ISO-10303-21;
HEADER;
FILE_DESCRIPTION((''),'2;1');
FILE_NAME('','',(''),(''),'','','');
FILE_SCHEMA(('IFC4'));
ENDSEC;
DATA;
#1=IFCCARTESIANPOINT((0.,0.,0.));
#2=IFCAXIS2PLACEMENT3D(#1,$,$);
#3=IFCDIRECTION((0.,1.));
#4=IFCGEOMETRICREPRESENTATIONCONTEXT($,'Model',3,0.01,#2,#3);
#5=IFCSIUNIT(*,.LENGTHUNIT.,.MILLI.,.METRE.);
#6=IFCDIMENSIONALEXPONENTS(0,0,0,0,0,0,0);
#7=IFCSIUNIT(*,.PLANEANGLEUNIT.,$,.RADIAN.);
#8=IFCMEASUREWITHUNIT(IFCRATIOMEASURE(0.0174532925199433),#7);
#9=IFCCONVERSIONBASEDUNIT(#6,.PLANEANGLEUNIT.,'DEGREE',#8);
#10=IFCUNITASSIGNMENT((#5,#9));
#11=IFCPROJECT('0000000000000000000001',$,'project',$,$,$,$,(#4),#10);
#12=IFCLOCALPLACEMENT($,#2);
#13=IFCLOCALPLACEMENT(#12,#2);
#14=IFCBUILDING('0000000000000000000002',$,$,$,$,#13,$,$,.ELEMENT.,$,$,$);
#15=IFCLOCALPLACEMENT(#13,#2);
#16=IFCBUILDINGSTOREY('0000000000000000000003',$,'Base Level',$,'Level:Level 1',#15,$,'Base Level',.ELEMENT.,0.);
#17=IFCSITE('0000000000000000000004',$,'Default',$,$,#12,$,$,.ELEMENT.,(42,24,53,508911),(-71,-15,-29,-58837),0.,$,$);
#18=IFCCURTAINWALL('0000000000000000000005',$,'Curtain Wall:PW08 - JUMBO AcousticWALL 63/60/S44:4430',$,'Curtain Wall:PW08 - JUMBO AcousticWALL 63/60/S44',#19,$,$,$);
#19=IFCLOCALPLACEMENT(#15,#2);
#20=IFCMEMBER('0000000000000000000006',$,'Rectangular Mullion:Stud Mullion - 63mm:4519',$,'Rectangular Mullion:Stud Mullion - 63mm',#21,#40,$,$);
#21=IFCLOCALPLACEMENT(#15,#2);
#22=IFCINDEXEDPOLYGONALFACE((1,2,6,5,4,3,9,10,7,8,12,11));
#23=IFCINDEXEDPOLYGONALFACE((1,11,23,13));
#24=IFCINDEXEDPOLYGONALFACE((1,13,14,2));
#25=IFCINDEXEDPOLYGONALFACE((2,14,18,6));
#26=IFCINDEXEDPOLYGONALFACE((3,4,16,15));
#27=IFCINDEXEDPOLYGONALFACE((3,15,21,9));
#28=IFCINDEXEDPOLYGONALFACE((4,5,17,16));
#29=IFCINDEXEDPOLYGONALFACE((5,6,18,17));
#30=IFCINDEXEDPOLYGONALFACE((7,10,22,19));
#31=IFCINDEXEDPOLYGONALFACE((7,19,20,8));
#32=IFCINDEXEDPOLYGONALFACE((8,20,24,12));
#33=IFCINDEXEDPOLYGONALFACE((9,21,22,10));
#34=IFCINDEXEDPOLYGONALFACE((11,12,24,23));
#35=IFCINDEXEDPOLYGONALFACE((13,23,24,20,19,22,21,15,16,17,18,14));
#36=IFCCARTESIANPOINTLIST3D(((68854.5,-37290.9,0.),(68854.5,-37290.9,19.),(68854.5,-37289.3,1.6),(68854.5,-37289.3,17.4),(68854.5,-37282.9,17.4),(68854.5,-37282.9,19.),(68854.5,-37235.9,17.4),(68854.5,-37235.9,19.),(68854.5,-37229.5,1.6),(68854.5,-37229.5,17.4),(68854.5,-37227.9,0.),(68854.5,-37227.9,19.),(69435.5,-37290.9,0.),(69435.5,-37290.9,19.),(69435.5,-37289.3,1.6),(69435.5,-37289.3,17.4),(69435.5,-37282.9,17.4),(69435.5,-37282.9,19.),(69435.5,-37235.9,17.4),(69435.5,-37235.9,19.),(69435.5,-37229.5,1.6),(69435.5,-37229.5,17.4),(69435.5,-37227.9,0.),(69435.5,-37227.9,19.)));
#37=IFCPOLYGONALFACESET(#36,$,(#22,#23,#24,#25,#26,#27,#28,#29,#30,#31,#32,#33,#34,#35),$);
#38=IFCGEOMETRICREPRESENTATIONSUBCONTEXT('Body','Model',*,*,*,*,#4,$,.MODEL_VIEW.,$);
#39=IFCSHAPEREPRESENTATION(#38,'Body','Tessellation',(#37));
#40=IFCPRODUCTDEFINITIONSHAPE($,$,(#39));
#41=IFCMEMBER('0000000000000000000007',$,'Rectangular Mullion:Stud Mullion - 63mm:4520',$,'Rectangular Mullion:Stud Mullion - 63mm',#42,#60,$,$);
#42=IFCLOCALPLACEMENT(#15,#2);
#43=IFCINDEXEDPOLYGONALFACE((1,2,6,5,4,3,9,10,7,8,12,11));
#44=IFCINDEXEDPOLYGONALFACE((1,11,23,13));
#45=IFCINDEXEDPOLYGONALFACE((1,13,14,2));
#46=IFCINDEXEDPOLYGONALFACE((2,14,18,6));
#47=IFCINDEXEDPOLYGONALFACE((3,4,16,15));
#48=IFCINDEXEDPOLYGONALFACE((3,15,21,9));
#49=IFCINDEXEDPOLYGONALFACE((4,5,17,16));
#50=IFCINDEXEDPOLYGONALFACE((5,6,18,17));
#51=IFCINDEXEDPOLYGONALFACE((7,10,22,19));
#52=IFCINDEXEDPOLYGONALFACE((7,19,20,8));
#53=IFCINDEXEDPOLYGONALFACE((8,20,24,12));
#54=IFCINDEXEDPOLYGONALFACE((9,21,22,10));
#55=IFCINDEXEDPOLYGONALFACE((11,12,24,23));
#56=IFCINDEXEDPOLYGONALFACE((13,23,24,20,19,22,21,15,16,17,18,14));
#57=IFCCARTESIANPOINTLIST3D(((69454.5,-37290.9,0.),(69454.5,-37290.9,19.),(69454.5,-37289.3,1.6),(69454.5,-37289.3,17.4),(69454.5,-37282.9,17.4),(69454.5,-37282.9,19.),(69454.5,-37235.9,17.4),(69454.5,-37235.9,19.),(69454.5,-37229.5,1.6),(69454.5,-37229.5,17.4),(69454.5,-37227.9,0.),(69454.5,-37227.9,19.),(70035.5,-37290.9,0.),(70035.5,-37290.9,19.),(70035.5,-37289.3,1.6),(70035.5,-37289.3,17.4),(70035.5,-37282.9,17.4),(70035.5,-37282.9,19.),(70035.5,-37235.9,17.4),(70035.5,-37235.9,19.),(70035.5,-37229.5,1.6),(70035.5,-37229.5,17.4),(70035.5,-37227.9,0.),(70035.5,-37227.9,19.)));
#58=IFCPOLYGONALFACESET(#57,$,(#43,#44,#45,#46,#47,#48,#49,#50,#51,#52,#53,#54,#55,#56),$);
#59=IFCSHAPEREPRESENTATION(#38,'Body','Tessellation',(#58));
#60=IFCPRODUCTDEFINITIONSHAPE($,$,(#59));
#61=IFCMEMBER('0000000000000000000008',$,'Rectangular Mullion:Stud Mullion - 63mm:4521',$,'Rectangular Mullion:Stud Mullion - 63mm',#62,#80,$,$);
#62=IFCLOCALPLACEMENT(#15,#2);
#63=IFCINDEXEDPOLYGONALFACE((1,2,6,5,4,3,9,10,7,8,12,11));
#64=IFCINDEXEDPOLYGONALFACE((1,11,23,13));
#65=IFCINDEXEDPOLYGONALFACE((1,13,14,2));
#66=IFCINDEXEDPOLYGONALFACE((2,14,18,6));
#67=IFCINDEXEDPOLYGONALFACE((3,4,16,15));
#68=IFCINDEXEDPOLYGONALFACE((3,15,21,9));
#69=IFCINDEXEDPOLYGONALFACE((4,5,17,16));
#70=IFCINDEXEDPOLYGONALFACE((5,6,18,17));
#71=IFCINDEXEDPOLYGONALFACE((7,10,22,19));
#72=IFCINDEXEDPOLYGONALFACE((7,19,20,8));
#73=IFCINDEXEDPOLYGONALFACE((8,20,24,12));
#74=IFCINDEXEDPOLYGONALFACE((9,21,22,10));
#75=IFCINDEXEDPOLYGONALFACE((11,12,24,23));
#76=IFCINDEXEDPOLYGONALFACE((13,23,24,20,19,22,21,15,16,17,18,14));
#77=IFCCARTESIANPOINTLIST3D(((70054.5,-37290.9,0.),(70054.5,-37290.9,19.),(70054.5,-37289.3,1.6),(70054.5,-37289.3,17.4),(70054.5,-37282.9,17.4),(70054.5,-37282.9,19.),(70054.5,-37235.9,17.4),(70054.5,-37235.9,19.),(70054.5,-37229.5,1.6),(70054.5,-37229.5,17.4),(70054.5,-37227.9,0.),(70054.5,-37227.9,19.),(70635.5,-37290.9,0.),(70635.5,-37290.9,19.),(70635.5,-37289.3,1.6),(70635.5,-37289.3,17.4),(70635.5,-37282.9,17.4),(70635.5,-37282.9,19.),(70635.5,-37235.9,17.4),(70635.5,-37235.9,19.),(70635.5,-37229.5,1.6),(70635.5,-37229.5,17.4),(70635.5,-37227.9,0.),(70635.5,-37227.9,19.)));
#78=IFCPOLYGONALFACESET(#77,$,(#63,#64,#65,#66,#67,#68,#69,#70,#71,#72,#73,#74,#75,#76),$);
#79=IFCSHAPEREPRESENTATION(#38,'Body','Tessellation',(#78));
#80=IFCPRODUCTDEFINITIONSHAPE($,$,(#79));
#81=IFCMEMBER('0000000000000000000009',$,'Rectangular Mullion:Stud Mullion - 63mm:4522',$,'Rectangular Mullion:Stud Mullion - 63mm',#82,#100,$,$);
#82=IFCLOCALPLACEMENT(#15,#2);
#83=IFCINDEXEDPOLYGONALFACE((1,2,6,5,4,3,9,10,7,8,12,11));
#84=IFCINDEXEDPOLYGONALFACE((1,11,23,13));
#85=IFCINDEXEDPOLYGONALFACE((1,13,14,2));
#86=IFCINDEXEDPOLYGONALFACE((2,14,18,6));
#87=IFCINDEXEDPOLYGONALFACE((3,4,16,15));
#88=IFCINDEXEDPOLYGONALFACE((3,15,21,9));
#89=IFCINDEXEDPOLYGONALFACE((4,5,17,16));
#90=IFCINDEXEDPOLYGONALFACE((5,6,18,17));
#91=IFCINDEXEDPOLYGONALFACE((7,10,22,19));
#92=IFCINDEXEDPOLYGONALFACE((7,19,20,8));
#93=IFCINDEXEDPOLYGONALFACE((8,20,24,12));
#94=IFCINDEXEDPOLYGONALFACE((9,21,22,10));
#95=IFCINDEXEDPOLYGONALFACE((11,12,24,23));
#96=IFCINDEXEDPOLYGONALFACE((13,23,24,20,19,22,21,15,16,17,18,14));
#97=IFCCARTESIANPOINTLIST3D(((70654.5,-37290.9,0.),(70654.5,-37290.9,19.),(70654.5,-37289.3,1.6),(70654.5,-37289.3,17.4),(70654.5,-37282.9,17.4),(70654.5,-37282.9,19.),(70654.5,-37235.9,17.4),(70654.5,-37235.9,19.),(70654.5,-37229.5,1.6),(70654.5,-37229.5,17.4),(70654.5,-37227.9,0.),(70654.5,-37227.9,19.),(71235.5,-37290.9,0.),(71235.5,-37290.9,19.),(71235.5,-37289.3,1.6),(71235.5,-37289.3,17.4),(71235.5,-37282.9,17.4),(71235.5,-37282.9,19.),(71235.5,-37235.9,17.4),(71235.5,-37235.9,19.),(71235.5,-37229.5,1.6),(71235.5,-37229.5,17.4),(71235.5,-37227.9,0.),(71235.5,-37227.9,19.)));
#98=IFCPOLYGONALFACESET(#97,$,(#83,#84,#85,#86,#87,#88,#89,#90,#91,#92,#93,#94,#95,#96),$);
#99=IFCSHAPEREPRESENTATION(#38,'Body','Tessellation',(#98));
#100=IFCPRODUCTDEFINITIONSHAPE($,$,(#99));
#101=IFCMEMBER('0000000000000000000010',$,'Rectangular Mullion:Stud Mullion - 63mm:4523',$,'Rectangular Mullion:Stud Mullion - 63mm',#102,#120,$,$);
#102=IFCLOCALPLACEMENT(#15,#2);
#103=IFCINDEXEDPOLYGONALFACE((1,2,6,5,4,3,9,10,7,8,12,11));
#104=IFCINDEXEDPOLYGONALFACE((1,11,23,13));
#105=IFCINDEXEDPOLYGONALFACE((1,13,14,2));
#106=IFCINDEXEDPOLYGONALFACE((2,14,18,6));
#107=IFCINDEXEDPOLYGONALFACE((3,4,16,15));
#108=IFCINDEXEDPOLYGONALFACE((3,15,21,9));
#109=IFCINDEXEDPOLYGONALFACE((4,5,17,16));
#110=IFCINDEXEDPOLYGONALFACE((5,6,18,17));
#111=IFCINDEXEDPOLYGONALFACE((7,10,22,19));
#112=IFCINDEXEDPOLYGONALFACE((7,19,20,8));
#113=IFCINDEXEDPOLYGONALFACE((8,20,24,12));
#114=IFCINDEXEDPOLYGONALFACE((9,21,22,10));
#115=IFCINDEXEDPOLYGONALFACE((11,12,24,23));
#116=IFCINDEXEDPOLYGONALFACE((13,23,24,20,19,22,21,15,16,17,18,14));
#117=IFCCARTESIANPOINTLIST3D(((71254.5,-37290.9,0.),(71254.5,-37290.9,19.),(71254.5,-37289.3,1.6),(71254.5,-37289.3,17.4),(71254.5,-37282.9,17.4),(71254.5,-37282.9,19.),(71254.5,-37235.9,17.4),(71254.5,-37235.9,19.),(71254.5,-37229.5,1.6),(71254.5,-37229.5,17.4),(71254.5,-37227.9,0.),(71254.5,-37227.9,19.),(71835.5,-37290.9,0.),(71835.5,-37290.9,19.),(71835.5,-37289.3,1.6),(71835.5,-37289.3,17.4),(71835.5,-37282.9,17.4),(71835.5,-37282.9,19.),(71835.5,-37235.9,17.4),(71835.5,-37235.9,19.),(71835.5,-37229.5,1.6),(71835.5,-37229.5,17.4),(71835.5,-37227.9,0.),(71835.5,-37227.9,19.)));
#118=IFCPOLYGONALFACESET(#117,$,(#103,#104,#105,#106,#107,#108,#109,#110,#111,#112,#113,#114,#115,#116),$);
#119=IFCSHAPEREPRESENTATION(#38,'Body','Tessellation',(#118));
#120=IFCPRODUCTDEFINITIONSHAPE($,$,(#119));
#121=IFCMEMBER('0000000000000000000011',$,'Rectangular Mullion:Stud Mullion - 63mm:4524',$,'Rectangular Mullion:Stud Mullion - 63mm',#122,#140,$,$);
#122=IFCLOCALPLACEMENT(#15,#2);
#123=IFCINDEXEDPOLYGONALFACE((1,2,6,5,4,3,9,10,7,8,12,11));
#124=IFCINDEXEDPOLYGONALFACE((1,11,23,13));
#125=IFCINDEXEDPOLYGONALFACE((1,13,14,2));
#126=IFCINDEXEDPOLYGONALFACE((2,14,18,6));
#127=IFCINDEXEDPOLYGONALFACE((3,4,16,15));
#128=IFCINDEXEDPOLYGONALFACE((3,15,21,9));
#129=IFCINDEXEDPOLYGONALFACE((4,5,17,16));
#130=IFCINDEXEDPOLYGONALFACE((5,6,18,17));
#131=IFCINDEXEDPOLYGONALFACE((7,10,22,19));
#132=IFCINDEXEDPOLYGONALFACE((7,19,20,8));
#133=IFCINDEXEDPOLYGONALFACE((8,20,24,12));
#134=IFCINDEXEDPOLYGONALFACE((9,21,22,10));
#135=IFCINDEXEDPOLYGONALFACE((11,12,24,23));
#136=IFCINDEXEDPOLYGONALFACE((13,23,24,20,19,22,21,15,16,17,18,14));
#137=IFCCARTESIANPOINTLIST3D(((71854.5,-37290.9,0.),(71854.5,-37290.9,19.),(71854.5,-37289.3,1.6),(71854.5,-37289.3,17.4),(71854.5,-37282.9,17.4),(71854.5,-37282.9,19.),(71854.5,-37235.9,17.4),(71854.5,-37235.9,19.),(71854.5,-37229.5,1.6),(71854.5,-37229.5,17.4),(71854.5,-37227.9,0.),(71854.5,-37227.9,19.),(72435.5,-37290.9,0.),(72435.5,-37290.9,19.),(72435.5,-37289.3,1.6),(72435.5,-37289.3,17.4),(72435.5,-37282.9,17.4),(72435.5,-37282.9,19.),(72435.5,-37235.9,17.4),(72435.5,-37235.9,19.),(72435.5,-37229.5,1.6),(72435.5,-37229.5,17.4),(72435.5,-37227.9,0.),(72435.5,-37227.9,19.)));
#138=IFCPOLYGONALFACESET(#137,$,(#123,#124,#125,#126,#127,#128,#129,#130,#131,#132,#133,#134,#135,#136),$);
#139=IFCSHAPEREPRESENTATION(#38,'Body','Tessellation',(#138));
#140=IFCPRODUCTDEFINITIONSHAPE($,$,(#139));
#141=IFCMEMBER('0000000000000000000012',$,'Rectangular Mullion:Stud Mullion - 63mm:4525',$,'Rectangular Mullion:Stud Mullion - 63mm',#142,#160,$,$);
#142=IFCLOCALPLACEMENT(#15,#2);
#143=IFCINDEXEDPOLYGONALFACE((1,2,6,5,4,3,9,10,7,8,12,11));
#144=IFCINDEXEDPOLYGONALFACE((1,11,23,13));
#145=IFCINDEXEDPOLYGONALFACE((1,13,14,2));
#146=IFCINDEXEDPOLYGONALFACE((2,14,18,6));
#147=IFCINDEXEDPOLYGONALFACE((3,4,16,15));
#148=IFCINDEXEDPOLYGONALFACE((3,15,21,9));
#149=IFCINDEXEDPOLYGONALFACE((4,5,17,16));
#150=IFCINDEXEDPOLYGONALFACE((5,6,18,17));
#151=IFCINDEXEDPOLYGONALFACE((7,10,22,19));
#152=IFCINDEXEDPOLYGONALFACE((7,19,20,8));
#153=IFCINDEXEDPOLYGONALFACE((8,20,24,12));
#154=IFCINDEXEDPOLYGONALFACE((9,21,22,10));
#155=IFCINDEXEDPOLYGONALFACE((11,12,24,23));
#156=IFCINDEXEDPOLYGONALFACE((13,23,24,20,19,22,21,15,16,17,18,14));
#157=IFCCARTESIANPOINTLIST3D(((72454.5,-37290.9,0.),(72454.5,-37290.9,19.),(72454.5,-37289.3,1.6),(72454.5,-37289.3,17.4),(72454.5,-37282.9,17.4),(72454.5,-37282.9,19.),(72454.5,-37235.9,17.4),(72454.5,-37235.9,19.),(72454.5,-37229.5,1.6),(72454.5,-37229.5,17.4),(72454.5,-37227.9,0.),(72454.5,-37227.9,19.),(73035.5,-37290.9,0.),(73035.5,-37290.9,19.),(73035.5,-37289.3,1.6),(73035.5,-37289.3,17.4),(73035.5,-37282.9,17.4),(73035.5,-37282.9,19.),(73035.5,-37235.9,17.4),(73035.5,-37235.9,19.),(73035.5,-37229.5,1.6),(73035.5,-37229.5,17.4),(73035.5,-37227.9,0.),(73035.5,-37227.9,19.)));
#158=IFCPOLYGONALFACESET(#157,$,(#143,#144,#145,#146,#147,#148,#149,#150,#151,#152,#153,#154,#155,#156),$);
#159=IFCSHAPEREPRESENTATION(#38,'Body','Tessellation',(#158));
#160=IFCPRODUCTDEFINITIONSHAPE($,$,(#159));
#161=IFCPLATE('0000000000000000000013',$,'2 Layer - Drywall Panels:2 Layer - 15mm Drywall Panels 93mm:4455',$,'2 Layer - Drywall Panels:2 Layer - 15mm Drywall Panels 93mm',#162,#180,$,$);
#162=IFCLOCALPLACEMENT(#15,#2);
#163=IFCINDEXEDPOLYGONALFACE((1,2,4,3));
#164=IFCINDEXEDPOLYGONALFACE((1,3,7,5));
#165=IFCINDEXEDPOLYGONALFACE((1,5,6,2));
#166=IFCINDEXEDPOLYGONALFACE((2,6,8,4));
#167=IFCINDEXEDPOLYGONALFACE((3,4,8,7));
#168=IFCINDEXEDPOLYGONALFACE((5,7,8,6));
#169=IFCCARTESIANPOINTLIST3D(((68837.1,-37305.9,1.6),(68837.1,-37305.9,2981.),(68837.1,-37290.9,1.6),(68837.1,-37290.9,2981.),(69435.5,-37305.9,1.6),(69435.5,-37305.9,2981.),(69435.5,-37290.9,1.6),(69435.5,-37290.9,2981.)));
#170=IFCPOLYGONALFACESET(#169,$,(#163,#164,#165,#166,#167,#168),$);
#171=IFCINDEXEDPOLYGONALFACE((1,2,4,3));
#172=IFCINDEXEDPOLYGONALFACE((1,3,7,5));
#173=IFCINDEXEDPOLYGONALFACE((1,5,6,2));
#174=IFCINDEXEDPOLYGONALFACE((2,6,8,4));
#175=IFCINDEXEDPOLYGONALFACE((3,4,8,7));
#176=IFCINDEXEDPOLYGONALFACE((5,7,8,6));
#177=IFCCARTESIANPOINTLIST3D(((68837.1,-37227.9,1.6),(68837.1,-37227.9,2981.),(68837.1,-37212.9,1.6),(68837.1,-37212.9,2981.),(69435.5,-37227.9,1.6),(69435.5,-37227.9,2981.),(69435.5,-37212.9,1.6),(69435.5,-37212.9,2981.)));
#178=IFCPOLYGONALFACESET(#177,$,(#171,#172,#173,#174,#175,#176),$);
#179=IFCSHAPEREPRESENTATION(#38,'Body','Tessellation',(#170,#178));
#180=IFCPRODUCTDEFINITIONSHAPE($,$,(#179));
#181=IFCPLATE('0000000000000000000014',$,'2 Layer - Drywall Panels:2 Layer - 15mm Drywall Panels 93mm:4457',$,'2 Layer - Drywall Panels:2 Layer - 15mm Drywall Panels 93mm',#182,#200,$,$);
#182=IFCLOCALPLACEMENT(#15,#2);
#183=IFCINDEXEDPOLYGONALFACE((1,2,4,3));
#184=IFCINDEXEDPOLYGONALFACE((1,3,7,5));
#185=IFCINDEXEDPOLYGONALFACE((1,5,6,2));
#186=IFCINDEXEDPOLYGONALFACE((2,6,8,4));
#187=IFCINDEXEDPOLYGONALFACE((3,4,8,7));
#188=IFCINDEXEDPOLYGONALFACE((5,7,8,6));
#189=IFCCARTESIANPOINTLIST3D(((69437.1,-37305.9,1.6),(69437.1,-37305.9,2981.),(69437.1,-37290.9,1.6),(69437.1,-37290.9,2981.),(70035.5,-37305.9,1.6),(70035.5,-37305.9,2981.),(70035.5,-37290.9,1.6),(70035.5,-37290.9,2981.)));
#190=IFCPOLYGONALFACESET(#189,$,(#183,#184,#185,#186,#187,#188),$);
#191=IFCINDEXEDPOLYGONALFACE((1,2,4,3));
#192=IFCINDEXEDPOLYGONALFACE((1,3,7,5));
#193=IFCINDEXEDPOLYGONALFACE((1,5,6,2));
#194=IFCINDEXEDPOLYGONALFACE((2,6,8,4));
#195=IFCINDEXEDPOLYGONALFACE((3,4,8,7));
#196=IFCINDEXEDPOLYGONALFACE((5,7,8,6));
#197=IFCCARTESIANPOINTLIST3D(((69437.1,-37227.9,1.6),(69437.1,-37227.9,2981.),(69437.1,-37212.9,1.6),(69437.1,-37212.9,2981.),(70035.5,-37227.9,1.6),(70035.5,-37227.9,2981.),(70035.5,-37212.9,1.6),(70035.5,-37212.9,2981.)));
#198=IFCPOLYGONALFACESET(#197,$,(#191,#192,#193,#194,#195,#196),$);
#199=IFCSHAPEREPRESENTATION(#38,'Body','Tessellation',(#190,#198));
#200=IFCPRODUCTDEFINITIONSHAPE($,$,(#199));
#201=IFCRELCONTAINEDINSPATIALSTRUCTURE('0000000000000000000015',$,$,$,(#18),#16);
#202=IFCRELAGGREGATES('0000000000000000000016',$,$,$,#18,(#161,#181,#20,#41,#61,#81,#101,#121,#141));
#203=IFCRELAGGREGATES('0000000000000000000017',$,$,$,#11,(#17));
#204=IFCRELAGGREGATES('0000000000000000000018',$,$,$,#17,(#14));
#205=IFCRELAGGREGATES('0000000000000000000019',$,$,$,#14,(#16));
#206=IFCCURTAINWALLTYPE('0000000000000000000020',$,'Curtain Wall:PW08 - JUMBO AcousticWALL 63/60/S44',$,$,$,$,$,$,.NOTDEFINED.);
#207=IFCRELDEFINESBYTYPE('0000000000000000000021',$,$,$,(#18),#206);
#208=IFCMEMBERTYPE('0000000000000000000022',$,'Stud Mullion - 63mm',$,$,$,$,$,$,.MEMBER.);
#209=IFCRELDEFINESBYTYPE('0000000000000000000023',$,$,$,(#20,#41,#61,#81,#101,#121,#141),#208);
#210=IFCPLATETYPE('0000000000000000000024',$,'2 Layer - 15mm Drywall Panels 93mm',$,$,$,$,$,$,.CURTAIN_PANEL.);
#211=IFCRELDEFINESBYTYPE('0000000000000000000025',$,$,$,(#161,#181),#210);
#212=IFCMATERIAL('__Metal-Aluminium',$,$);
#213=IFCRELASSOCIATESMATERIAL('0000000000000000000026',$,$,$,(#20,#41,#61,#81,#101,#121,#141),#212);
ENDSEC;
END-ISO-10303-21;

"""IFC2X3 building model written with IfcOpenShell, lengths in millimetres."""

from ifc_helpers import new_model, entity, si_unit, converted_unit, direction, frame, frame_2d, origin, place, context, subcontext, project, spatial, polyline, rectangle, outline, extrude, source, transform, mapped, material, type_object, type_shapes, element, aggregate, save


model = new_model("IFC2X3")

# Units and contexts
model_context = context("Model", 3, precision=0.01, world=origin(), true_north=direction((0.0, 1.0)))
body_context = subcontext(model_context, "Body", "Model", "MODEL_VIEW")
ifc_project = project(units=[si_unit("LENGTHUNIT", "METRE", prefix="MILLI"), converted_unit("PLANEANGLEUNIT", "DEGREE", entity("IfcRatioMeasure", 0.0174532925199433), si_unit("PLANEANGLEUNIT", "RADIAN"), dimensions=[0, 0, 0, 0, 0, 0, 0])], contexts=[model_context])

# Site, building, storey
site_placement = place(None, origin())
site = spatial("IfcSite", under=ifc_project, at=site_placement, Name="Default", CompositionType="ELEMENT", RefLatitude=(42, 24, 53, 508911), RefLongitude=(-71, -15, -29, -58837), RefElevation=0.0)
building_placement = place(site_placement, origin())
building = spatial("IfcBuilding", under=site, at=building_placement, CompositionType="ELEMENT")
storey_placement = place(building_placement, origin())
storey = spatial("IfcBuildingStorey", under=building, at=storey_placement, Name="Base Level", ObjectType="Level:Level 1", LongName="Base Level", CompositionType="ELEMENT", Elevation=0.0)

# Curtain wall, members, plates
curtain_wall_type = type_object("IfcCurtainWallType", Name="Curtain Wall:PW08 - JUMBO AcousticWALL 63/60/S44", PredefinedType="NOTDEFINED")
curtain_wall_placement = place(building_placement, origin())
curtain_wall = element("IfcCurtainWall", 1, at=curtain_wall_placement, inside=storey, type_object=curtain_wall_type, Name="Curtain Wall:PW08 - JUMBO AcousticWALL 63/60/S44:4430", ObjectType="Curtain Wall:PW08 - JUMBO AcousticWALL 63/60/S44")
ifc_material = material(Name="__Metal-Aluminium")
member_type_1 = type_object("IfcMemberType", Name="Stud Mullion - 63mm", PredefinedType="MEMBER")
shared_shape_1 = source(origin(), body_context, "Body", "SweptSolid", [
    extrude(outline(polyline([(23.5, -6.6), (31.5, -6.6), (31.5, 12.4), (-31.5, 12.4), (-31.5, -6.6), (-23.5, -6.6), (-23.5, -5.0), (-29.9, -5.0), (-29.9, 10.8), (29.9, 10.8), (29.9, -5.0), (23.5, -5.0), (23.5, -6.6)])), frame((-12.4, 0.0, -581.0), z_axis=(0.0, 0.0, 1.0), x_axis=(0.0, -1.0, 0.0)), (0.0, 0.0, 1.0), 581.0),
])
type_shapes(member_type_1, [shared_shape_1])
member_1_placement = place(building_placement, frame((68854.5, -37259.4, 0.0), z_axis=(-1.0, 0.0, 0.0), x_axis=(0.0, 0.0, -1.0)))
member_1 = element("IfcMember", 2, at=member_1_placement, type_object=member_type_1, material=ifc_material, Name="Rectangular Mullion:Stud Mullion - 63mm:4519", ObjectType="Rectangular Mullion:Stud Mullion - 63mm", context=body_context, shape_type="MappedRepresentation", body=[
    mapped(shared_shape_1, transform((0.0, 0.0, 0.0), scale=1.0)),
])
member_2_placement = place(building_placement, frame((69454.5, -37259.4, 0.0), z_axis=(-1.0, 0.0, 0.0), x_axis=(0.0, 0.0, -1.0)))
member_2 = element("IfcMember", 3, at=member_2_placement, type_object=member_type_1, material=ifc_material, Name="Rectangular Mullion:Stud Mullion - 63mm:4520", ObjectType="Rectangular Mullion:Stud Mullion - 63mm", context=body_context, shape_type="MappedRepresentation", body=[
    mapped(shared_shape_1, transform((0.0, 0.0, 0.0), scale=1.0)),
])
member_3_placement = place(building_placement, frame((70054.5, -37259.4, 0.0), z_axis=(-1.0, 0.0, 0.0), x_axis=(0.0, 0.0, -1.0)))
member_3 = element("IfcMember", 4, at=member_3_placement, type_object=member_type_1, material=ifc_material, Name="Rectangular Mullion:Stud Mullion - 63mm:4521", ObjectType="Rectangular Mullion:Stud Mullion - 63mm", context=body_context, shape_type="MappedRepresentation", body=[
    mapped(shared_shape_1, transform((0.0, 0.0, 0.0), scale=1.0)),
])
member_4_placement = place(building_placement, frame((70654.5, -37259.4, 0.0), z_axis=(-1.0, 0.0, 0.0), x_axis=(0.0, 0.0, -1.0)))
member_4 = element("IfcMember", 5, at=member_4_placement, type_object=member_type_1, material=ifc_material, Name="Rectangular Mullion:Stud Mullion - 63mm:4522", ObjectType="Rectangular Mullion:Stud Mullion - 63mm", context=body_context, shape_type="MappedRepresentation", body=[
    mapped(shared_shape_1, transform((0.0, 0.0, 0.0), scale=1.0)),
])
member_5_placement = place(building_placement, frame((71254.5, -37259.4, 0.0), z_axis=(-1.0, 0.0, 0.0), x_axis=(0.0, 0.0, -1.0)))
member_5 = element("IfcMember", 6, at=member_5_placement, type_object=member_type_1, material=ifc_material, Name="Rectangular Mullion:Stud Mullion - 63mm:4523", ObjectType="Rectangular Mullion:Stud Mullion - 63mm", context=body_context, shape_type="MappedRepresentation", body=[
    mapped(shared_shape_1, transform((0.0, 0.0, 0.0), scale=1.0)),
])
member_6_placement = place(building_placement, frame((71854.5, -37259.4, 0.0), z_axis=(-1.0, 0.0, 0.0), x_axis=(0.0, 0.0, -1.0)))
member_6 = element("IfcMember", 7, at=member_6_placement, type_object=member_type_1, material=ifc_material, Name="Rectangular Mullion:Stud Mullion - 63mm:4524", ObjectType="Rectangular Mullion:Stud Mullion - 63mm", context=body_context, shape_type="MappedRepresentation", body=[
    mapped(shared_shape_1, transform((0.0, 0.0, 0.0), scale=1.0)),
])
member_7_placement = place(building_placement, frame((72454.5, -37259.4, 0.0), z_axis=(-1.0, 0.0, 0.0), x_axis=(0.0, 0.0, -1.0)))
member_7 = element("IfcMember", 8, at=member_7_placement, type_object=member_type_1, material=ifc_material, Name="Rectangular Mullion:Stud Mullion - 63mm:4525", ObjectType="Rectangular Mullion:Stud Mullion - 63mm", context=body_context, shape_type="MappedRepresentation", body=[
    mapped(shared_shape_1, transform((0.0, 0.0, 0.0), scale=1.0)),
])
plate_type = type_object("IfcPlateType", Name="2 Layer - 15mm Drywall Panels 93mm", PredefinedType="CURTAIN_PANEL")
shared_shape_2 = source(origin(), body_context, "Body", "SweptSolid", [
    extrude(rectangle(XDim=598.4, YDim=15.0, at=frame_2d((0.0, 0.0), x_axis=(1.0, 0.0))), frame((0.0, -39.0, 0.0), z_axis=(0.0, 0.0, 1.0), x_axis=(-1.0, 0.0, 0.0)), (0.0, 0.0, 1.0), 2979.4),
    extrude(rectangle(XDim=15.0, YDim=598.4, at=frame_2d((0.0, 0.0), x_axis=(1.0, 0.0))), frame((0.0, 39.0, 0.0), z_axis=(0.0, 0.0, 1.0), x_axis=(0.0, 1.0, 0.0)), (0.0, 0.0, 1.0), 2979.4),
])
type_shapes(plate_type, [shared_shape_2])
plate_1_placement = place(curtain_wall_placement, frame((69136.3, -37259.4, 1.6)))
plate_1 = element("IfcPlate", 9, at=plate_1_placement, type_object=plate_type, Name="2 Layer - Drywall Panels:2 Layer - 15mm Drywall Panels 93mm:4455", ObjectType="2 Layer - Drywall Panels:2 Layer - 15mm Drywall Panels 93mm", context=body_context, shape_type="MappedRepresentation", body=[
    mapped(shared_shape_2, transform((0.0, 0.0, 0.0), scale=1.0)),
])
plate_2_placement = place(curtain_wall_placement, frame((69736.3, -37259.4, 1.6)))
plate_2 = element("IfcPlate", 10, at=plate_2_placement, type_object=plate_type, Name="2 Layer - Drywall Panels:2 Layer - 15mm Drywall Panels 93mm:4457", ObjectType="2 Layer - Drywall Panels:2 Layer - 15mm Drywall Panels 93mm", context=body_context, shape_type="MappedRepresentation", body=[
    mapped(shared_shape_2, transform((0.0, 0.0, 0.0), scale=1.0)),
])
aggregate(curtain_wall, [plate_1, plate_2, member_1, member_2, member_3, member_4, member_5, member_6, member_7])

save(model, "model.ifc")
